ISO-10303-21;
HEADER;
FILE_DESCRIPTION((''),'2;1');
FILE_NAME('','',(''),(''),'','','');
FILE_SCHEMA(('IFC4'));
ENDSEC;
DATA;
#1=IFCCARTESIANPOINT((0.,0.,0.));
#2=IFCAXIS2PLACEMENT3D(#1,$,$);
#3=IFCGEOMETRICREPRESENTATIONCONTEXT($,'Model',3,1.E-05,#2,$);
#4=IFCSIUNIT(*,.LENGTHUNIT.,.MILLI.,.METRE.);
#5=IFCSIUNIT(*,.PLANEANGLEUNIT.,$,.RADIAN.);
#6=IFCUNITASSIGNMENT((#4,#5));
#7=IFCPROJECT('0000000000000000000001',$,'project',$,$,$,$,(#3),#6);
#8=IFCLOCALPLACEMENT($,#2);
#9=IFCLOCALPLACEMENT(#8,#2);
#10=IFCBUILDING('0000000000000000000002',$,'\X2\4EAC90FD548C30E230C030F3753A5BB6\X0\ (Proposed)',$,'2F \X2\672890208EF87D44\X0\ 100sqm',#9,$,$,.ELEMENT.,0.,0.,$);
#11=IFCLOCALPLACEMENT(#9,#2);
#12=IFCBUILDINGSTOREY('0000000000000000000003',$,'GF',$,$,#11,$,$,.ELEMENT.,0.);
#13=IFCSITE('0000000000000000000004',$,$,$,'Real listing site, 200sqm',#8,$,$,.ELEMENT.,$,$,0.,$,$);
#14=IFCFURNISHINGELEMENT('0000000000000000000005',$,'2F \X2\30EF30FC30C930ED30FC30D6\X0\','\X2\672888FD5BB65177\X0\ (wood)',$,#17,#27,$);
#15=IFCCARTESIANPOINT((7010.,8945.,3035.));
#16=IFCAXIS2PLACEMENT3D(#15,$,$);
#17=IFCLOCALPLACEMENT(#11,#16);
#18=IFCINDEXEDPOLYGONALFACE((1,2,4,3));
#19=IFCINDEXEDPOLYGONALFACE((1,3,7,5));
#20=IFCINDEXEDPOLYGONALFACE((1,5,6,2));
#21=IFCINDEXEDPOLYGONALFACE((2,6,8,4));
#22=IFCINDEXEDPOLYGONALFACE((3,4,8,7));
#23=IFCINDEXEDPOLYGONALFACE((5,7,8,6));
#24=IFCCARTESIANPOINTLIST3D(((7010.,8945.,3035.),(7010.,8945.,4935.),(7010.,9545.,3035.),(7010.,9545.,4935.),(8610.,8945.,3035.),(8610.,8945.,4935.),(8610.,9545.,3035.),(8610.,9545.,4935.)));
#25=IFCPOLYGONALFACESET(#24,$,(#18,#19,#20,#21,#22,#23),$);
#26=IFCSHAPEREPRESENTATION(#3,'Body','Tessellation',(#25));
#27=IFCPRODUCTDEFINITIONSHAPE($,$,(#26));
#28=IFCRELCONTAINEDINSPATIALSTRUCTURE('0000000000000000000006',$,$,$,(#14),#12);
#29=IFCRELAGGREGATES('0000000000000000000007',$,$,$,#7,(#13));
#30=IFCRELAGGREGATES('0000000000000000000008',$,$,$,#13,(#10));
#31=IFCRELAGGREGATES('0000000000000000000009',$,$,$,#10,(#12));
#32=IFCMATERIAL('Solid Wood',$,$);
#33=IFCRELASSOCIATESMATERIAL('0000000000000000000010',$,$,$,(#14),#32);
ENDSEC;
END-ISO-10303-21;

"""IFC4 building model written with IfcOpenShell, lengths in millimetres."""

from ifc_helpers import new_model, si_unit, frame, frame_2d, origin, place, context, project, spatial, rectangle, extrude, material, element, save


model = new_model("IFC4")

# Units and contexts
model_context = context("Model", 3, precision=1e-05, world=origin())
ifc_project = project(units=[si_unit("LENGTHUNIT", "METRE", prefix="MILLI"), si_unit("PLANEANGLEUNIT", "RADIAN")], contexts=[model_context])

# Site, building, storey
site_placement = place(None, origin())
site = spatial("IfcSite", under=ifc_project, at=site_placement, ObjectType="Real listing site, 200sqm", CompositionType="ELEMENT", RefElevation=0.0)
building_placement = place(site_placement, origin())
building = spatial("IfcBuilding", under=site, at=building_placement, Name="京都和モダン町家 (Proposed)", ObjectType="2F 木造軸組 100sqm", CompositionType="ELEMENT", ElevationOfRefHeight=0.0, ElevationOfTerrain=0.0)
storey_placement = place(building_placement, origin())
storey = spatial("IfcBuildingStorey", under=building, at=storey_placement, Name="GF", CompositionType="ELEMENT", Elevation=0.0)

# Shared definitions
ifc_material_1 = material(Name="Solid Wood")

# Furnishing element
furnishing_1_placement = place(storey_placement, frame((7010.0, 8945.0, 3035.0)))
element("IfcFurnishingElement", 1, at=furnishing_1_placement, inside=storey, material=ifc_material_1, Name="2F ワードローブ", Description="木製家具 (wood)", context=model_context, shape_type="SweptSolid", body=[
    extrude(rectangle(XDim=1600.0, YDim=600.0, at=frame_2d((800.0, 300.0))), frame((7010.0, 8945.0, 3035.0)), (0.0, 0.0, 1.0), 1900.0),
])

save(model, "model.ifc")
